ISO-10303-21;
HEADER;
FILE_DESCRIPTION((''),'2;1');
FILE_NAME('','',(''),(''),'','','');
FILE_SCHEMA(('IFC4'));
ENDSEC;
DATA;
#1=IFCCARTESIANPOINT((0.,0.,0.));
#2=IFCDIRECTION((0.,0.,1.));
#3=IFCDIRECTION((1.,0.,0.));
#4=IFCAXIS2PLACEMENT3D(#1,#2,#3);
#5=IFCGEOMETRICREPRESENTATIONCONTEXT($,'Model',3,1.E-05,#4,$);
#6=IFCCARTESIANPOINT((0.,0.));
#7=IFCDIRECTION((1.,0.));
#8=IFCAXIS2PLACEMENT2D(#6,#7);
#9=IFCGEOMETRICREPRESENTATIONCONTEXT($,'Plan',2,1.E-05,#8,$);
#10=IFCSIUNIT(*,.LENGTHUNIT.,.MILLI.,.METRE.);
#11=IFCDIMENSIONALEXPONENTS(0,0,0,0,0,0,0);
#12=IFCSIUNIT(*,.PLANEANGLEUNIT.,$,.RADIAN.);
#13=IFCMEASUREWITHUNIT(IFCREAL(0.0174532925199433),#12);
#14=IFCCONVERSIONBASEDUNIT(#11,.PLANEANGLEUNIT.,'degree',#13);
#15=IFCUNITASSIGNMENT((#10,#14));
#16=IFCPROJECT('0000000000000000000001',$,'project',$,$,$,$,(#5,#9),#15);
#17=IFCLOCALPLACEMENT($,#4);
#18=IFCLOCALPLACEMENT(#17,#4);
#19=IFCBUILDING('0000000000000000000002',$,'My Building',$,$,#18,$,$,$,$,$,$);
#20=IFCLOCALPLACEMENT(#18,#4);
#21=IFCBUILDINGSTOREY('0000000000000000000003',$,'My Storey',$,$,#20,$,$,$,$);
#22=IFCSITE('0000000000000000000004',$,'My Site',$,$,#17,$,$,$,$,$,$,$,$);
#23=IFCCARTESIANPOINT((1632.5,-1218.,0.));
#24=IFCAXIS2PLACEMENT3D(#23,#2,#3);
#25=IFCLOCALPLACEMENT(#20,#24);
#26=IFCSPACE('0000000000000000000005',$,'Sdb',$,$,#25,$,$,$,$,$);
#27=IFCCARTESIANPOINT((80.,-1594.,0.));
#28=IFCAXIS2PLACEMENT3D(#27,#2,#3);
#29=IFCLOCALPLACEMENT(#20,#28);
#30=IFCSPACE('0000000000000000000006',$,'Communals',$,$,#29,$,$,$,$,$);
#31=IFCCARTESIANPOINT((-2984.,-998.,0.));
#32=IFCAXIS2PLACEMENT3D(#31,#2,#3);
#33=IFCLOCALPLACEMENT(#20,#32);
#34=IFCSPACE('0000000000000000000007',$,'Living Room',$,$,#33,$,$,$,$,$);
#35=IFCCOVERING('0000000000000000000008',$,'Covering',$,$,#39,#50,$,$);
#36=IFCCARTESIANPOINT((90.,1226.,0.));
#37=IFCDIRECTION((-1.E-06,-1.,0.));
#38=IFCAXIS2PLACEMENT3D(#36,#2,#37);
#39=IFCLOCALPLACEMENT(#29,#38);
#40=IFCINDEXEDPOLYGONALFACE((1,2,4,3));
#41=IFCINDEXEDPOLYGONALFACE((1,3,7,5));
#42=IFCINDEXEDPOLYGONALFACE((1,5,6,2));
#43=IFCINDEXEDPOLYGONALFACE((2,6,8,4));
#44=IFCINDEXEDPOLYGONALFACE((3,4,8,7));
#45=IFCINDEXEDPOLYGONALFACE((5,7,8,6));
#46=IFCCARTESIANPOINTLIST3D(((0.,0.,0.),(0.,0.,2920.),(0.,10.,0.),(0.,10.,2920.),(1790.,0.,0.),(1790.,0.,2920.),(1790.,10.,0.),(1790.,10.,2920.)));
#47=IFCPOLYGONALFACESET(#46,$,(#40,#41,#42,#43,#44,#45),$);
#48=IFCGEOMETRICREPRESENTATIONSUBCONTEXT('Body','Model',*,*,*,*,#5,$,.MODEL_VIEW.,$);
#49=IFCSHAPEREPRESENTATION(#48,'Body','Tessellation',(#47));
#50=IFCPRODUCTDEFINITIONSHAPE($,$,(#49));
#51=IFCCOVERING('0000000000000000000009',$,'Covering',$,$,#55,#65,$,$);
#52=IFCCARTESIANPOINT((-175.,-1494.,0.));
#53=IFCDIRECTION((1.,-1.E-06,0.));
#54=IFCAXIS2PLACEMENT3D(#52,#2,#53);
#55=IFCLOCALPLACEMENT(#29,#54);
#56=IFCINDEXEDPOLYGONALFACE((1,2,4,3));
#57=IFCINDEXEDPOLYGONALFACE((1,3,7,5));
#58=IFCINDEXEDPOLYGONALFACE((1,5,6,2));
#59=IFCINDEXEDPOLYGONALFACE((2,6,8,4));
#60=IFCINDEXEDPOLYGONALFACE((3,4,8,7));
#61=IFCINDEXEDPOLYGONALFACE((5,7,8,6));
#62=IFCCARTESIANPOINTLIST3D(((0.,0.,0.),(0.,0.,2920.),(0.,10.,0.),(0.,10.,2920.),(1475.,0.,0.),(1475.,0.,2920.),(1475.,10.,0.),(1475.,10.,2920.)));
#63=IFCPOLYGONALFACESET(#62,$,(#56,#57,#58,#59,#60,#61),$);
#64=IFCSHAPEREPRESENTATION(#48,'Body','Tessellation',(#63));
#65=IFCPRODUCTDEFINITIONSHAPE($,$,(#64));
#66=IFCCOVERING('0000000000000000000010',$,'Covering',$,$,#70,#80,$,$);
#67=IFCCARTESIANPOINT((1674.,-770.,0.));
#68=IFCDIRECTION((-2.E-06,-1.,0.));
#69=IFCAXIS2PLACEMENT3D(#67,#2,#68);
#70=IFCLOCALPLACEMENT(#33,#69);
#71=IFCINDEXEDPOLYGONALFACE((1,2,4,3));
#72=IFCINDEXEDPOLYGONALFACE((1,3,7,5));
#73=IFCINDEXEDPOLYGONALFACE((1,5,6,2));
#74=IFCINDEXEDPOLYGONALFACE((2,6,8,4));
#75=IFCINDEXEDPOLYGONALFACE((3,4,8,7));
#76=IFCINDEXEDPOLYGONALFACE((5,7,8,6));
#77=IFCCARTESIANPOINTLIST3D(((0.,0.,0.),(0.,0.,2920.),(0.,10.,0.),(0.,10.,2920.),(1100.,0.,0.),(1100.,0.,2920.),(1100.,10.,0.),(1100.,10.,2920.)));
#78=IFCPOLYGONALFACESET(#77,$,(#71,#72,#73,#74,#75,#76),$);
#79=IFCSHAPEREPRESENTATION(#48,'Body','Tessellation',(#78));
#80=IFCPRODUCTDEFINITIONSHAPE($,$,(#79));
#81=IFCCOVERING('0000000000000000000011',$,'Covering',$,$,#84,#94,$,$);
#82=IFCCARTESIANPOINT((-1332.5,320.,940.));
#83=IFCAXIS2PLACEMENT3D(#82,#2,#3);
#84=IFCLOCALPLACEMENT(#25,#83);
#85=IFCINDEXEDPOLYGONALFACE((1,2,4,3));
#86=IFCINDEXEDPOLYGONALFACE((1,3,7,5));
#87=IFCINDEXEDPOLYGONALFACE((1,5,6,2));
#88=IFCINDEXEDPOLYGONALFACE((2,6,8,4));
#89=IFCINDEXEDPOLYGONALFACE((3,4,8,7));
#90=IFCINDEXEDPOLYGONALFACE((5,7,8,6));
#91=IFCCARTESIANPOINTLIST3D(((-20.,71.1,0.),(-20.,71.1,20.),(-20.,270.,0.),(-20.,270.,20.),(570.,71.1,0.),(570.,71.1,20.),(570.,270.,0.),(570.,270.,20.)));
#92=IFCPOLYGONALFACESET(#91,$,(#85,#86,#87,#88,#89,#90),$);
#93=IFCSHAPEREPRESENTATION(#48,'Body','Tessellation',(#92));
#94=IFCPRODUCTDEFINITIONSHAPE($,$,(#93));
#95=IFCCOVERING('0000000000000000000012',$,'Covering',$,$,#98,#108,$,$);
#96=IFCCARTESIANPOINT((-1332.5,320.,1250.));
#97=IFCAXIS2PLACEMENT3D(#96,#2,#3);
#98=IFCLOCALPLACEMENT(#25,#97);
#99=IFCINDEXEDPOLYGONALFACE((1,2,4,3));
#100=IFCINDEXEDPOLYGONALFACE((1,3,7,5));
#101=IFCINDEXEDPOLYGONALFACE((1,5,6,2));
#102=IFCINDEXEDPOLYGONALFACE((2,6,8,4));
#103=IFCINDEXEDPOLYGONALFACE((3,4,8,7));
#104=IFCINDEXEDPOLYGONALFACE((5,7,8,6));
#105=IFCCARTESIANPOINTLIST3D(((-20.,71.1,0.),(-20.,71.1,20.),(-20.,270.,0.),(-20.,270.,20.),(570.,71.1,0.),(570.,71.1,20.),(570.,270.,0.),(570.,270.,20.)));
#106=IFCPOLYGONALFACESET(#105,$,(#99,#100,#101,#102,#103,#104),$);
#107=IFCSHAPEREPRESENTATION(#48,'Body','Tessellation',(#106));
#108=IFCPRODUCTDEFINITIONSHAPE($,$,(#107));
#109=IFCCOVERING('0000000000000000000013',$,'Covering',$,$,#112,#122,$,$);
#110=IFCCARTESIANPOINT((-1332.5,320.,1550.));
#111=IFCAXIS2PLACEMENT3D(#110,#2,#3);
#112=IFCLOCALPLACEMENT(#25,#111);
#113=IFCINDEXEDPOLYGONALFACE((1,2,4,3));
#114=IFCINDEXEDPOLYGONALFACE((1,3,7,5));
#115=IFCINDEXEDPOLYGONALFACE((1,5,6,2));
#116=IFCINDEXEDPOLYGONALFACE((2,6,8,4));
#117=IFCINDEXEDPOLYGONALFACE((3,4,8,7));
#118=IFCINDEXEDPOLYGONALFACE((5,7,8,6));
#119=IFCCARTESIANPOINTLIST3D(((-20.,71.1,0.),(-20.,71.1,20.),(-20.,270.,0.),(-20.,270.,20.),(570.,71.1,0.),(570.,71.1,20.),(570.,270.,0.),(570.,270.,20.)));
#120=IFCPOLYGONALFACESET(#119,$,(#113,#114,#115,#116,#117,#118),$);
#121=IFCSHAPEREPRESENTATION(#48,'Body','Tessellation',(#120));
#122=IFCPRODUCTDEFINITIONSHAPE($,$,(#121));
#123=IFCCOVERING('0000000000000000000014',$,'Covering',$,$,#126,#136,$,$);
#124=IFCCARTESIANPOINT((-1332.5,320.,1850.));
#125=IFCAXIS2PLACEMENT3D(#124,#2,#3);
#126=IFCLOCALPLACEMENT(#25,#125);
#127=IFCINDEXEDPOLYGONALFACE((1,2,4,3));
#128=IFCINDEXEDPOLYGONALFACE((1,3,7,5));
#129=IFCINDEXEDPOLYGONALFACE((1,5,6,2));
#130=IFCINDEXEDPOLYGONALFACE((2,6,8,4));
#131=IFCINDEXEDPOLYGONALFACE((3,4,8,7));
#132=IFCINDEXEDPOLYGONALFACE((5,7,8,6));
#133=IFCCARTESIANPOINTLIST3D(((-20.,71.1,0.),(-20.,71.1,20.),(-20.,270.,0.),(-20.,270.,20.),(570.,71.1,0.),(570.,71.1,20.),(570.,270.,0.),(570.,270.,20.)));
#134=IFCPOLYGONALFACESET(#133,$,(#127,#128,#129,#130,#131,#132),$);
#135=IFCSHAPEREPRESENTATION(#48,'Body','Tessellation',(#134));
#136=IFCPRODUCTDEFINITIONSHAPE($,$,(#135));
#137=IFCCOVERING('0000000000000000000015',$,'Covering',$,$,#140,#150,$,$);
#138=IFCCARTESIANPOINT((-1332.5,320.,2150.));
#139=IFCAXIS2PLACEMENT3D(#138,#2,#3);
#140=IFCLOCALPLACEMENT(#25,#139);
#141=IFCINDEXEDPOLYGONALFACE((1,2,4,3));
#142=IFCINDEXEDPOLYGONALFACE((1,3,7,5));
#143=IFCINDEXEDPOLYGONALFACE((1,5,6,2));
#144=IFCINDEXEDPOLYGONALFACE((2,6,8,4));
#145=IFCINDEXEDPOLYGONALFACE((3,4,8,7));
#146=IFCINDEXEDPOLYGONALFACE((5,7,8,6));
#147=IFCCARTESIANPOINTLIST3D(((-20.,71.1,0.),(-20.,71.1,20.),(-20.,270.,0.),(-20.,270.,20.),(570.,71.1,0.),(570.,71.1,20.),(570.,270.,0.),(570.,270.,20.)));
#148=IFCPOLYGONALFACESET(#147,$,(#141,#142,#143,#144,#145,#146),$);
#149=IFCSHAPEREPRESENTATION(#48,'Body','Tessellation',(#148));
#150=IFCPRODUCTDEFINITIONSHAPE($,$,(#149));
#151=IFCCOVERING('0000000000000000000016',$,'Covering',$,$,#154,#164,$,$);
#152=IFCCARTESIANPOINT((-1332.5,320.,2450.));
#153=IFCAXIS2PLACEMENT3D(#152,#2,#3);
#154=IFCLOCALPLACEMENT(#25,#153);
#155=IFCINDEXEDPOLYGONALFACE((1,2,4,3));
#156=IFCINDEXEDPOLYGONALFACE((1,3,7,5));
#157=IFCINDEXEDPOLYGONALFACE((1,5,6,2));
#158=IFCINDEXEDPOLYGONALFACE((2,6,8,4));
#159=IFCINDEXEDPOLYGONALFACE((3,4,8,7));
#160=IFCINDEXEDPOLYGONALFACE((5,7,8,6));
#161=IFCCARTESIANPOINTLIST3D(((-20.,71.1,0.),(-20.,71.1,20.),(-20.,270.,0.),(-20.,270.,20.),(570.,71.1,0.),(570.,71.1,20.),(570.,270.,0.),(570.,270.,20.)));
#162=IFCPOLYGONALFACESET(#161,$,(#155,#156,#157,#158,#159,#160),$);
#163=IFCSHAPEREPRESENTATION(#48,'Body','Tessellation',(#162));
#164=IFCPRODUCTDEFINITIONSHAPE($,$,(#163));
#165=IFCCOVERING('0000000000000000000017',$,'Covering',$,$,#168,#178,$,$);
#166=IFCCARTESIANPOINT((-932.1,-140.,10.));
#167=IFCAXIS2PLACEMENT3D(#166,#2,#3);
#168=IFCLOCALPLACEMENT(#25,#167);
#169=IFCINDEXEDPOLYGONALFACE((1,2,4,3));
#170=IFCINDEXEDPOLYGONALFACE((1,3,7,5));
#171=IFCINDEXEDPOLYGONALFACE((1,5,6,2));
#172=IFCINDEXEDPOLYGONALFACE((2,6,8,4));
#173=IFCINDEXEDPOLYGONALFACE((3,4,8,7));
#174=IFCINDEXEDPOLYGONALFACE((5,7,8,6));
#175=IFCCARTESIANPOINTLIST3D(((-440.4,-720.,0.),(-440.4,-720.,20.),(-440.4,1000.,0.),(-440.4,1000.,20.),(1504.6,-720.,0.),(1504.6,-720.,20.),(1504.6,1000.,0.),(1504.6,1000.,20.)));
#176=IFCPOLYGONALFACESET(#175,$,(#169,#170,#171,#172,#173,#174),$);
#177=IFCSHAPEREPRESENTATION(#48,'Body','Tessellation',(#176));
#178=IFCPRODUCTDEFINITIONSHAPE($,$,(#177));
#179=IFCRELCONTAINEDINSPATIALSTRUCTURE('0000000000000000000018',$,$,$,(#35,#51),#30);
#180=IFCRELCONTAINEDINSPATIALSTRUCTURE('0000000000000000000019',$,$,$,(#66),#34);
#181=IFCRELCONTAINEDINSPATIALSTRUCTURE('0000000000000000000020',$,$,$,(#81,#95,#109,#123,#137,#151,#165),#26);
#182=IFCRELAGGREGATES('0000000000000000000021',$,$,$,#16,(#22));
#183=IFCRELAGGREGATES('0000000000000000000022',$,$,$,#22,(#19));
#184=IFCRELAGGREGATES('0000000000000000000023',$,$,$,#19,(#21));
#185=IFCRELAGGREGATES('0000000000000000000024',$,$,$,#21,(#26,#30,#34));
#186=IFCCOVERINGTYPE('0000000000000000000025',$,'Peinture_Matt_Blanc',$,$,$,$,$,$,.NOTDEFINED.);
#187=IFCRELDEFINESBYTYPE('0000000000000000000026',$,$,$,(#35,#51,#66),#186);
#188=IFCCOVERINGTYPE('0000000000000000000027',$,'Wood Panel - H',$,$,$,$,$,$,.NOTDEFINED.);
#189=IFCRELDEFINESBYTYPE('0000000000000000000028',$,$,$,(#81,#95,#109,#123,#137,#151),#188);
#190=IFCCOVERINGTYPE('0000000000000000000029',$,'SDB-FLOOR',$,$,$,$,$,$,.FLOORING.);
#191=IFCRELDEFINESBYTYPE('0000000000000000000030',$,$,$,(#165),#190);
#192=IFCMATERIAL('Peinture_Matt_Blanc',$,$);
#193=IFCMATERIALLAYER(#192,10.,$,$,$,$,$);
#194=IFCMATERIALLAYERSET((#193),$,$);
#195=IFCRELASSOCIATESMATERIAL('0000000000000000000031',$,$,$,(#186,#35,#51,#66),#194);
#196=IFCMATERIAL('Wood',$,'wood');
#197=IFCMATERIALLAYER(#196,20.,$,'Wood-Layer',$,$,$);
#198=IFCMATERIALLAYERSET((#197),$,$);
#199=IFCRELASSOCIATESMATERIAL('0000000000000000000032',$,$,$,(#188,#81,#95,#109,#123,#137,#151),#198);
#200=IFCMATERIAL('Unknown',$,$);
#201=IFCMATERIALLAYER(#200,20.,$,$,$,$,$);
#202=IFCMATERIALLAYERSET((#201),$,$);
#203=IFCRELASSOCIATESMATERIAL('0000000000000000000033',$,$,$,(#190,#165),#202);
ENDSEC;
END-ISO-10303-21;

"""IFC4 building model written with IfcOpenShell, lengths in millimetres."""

from ifc_helpers import new_model, entity, si_unit, converted_unit, frame, origin_with_axes, origin_2d_with_axis, place, context, subcontext, project, spatial, line, indexed_curve, outline, extrude, clip, halfspace, material, layer, layer_set, layer_usage, type_object, element, save


model = new_model("IFC4")

# Units and contexts
model_context = context("Model", 3, precision=1e-05, world=origin_with_axes())
plan_context = context("Plan", 2, precision=1e-05, world=origin_2d_with_axis())
body_context = subcontext(model_context, "Body", "Model", "MODEL_VIEW")
ifc_project = project(units=[si_unit("LENGTHUNIT", "METRE", prefix="MILLI"), converted_unit("PLANEANGLEUNIT", "degree", entity("IfcReal", 0.0174532925199433), si_unit("PLANEANGLEUNIT", "RADIAN"), dimensions=[0, 0, 0, 0, 0, 0, 0])], contexts=[model_context, plan_context])

# Site, building, storey, space
site_placement = place(None, origin_with_axes())
site = spatial("IfcSite", under=ifc_project, at=site_placement, Name="My Site")
building_placement = place(site_placement, origin_with_axes())
building = spatial("IfcBuilding", under=site, at=building_placement, Name="My Building")
storey_placement = place(building_placement, origin_with_axes())
storey = spatial("IfcBuildingStorey", under=building, at=storey_placement, Name="My Storey")
space_1_placement = place(storey_placement, frame((1632.5, -1218.0, 0.0), z_axis=(0.0, 0.0, 1.0), x_axis=(1.0, 0.0, 0.0)))
space_1 = spatial("IfcSpace", under=storey, at=space_1_placement, Name="Sdb")

# Shared definitions
space_2_placement = place(storey_placement, frame((80.0, -1594.0, 0.0), z_axis=(0.0, 0.0, 1.0), x_axis=(1.0, 0.0, 0.0)))
space_2 = spatial("IfcSpace", under=storey, at=space_2_placement, Name="Communals")

# Coverings
ifc_material_1 = material(Name="Peinture_Matt_Blanc")
ifc_layer_1 = layer(ifc_material_1, 10.0)
ifc_layer_set_1 = layer_set([ifc_layer_1])
ifc_layer_usage_1 = layer_usage(ifc_layer_set_1, "AXIS2", "POSITIVE", 0.0)
covering_type_1 = type_object("IfcCoveringType", Name="Peinture_Matt_Blanc", PredefinedType="NOTDEFINED", material=ifc_layer_set_1)
covering_1_placement = place(space_2_placement, frame((90.0, 1226.0, 0.0), z_axis=(0.0, 0.0, 1.0), x_axis=(-0.000001, -1.0, 0.0)))
element("IfcCovering", 1, at=covering_1_placement, inside=space_2, type_object=covering_type_1, material=ifc_layer_usage_1, Name="Covering", context=body_context, shape_type="Clipping", body=[
    clip(clip(extrude(outline(indexed_curve([(0.0, 0.0), (0.0, 10.0), (1790.0, 10.0), (1790.0, 0.0), (0.0, 0.0)], self_intersect=False)), origin_with_axes(), (0.0, 0.0, 1.0), 2920.0), halfspace(frame((0.0, 0.0, 2920.0), z_axis=(0.0, 0.0, 1.0), x_axis=(-1.0, 0.0, 0.0)), False)), halfspace(frame((0.0, 0.0, 2920.0), z_axis=(0.0, 0.0, 1.0), x_axis=(-1.0, 0.0, 0.0)), False)),
])
ifc_layer_usage_2 = layer_usage(ifc_layer_set_1, "AXIS2", "POSITIVE", 0.0)
covering_2_placement = place(space_2_placement, frame((-175.0, -1494.0, 0.0), z_axis=(0.0, 0.0, 1.0), x_axis=(1.0, -0.000001, 0.0)))
element("IfcCovering", 2, at=covering_2_placement, inside=space_2, type_object=covering_type_1, material=ifc_layer_usage_2, Name="Covering", context=body_context, shape_type="Clipping", body=[
    clip(clip(extrude(outline(indexed_curve([(0.0, 0.0), (0.0, 10.0), (1475.0, 10.0), (1475.0, 0.0), (0.0, 0.0)], self_intersect=False)), origin_with_axes(), (0.0, 0.0, 1.0), 2920.0), halfspace(frame((0.0, 0.0, 2920.0), z_axis=(0.0, 0.0, 1.0), x_axis=(-1.0, 0.0, 0.0)), False)), halfspace(frame((0.0, 0.0, 2920.0), z_axis=(0.0, 0.0, 1.0), x_axis=(-1.0, 0.0, 0.0)), False)),
])

# Shared definitions
space_3_placement = place(storey_placement, frame((-2984.0, -998.0, 0.0), z_axis=(0.0, 0.0, 1.0), x_axis=(1.0, 0.0, 0.0)))
space_3 = spatial("IfcSpace", under=storey, at=space_3_placement, Name="Living Room")

# Coverings
ifc_layer_usage_3 = layer_usage(ifc_layer_set_1, "AXIS2", "POSITIVE", 0.0)
covering_3_placement = place(space_3_placement, frame((1674.0, -770.0, 0.0), z_axis=(0.0, 0.0, 1.0), x_axis=(-0.000002, -1.0, 0.0)))
element("IfcCovering", 3, at=covering_3_placement, inside=space_3, type_object=covering_type_1, material=ifc_layer_usage_3, Name="Covering", context=body_context, shape_type="Clipping", body=[
    clip(clip(extrude(outline(indexed_curve([(0.0, 0.0), (0.0, 10.0), (1100.0, 10.0), (1100.0, 0.0), (0.0, 0.0)], self_intersect=False)), origin_with_axes(), (0.0, 0.0, 1.0), 2920.0), halfspace(frame((0.0, 0.0, 2920.0), z_axis=(0.0, 0.0, 1.0), x_axis=(-1.0, 0.0, 0.0)), False)), halfspace(frame((0.0, 0.0, 2920.0), z_axis=(0.0, 0.0, 1.0), x_axis=(-1.0, 0.0, 0.0)), False)),
])
ifc_material_2 = material(Name="Wood", Category="wood")
ifc_layer_2 = layer(ifc_material_2, 20.0, Name="Wood-Layer")
ifc_layer_set_2 = layer_set([ifc_layer_2])
ifc_layer_usage_4 = layer_usage(ifc_layer_set_2, "AXIS3", "POSITIVE", 0.0)
covering_type_2 = type_object("IfcCoveringType", Name="Wood Panel - H", PredefinedType="NOTDEFINED", material=ifc_layer_set_2)
covering_4_placement = place(space_1_placement, frame((-1332.5, 320.0, 940.0), z_axis=(0.0, 0.0, 1.0), x_axis=(1.0, 0.0, 0.0)))
element("IfcCovering", 4, at=covering_4_placement, inside=space_1, type_object=covering_type_2, material=ifc_layer_usage_4, Name="Covering", context=body_context, shape_type="SweptSolid", body=[
    extrude(outline(indexed_curve([(-20.0, 71.1), (570.0, 71.1), (570.0, 270.0), (-20.0, 270.0)], segments=[line(4, 1), line(1, 2), line(2, 3), line(3, 4)], self_intersect=False)), None, (0.0, 0.0, 1.0), 20.0),
])
ifc_layer_usage_5 = layer_usage(ifc_layer_set_2, "AXIS3", "POSITIVE", 0.0)
covering_5_placement = place(space_1_placement, frame((-1332.5, 320.0, 1250.0), z_axis=(0.0, 0.0, 1.0), x_axis=(1.0, 0.0, 0.0)))
element("IfcCovering", 5, at=covering_5_placement, inside=space_1, type_object=covering_type_2, material=ifc_layer_usage_5, Name="Covering", context=body_context, shape_type="SweptSolid", body=[
    extrude(outline(indexed_curve([(-20.0, 71.1), (570.0, 71.1), (570.0, 270.0), (-20.0, 270.0)], segments=[line(4, 1), line(1, 2), line(2, 3), line(3, 4)], self_intersect=False)), None, (0.0, 0.0, 1.0), 20.0),
])
ifc_layer_usage_6 = layer_usage(ifc_layer_set_2, "AXIS3", "POSITIVE", 0.0)
covering_6_placement = place(space_1_placement, frame((-1332.5, 320.0, 1550.0), z_axis=(0.0, 0.0, 1.0), x_axis=(1.0, 0.0, 0.0)))
element("IfcCovering", 6, at=covering_6_placement, inside=space_1, type_object=covering_type_2, material=ifc_layer_usage_6, Name="Covering", context=body_context, shape_type="SweptSolid", body=[
    extrude(outline(indexed_curve([(-20.0, 71.1), (570.0, 71.1), (570.0, 270.0), (-20.0, 270.0)], segments=[line(4, 1), line(1, 2), line(2, 3), line(3, 4)], self_intersect=False)), None, (0.0, 0.0, 1.0), 20.0),
])
ifc_layer_usage_7 = layer_usage(ifc_layer_set_2, "AXIS3", "POSITIVE", 0.0)
covering_7_placement = place(space_1_placement, frame((-1332.5, 320.0, 1850.0), z_axis=(0.0, 0.0, 1.0), x_axis=(1.0, 0.0, 0.0)))
element("IfcCovering", 7, at=covering_7_placement, inside=space_1, type_object=covering_type_2, material=ifc_layer_usage_7, Name="Covering", context=body_context, shape_type="SweptSolid", body=[
    extrude(outline(indexed_curve([(-20.0, 71.1), (570.0, 71.1), (570.0, 270.0), (-20.0, 270.0)], segments=[line(4, 1), line(1, 2), line(2, 3), line(3, 4)], self_intersect=False)), None, (0.0, 0.0, 1.0), 20.0),
])
ifc_layer_usage_8 = layer_usage(ifc_layer_set_2, "AXIS3", "POSITIVE", 0.0)
covering_8_placement = place(space_1_placement, frame((-1332.5, 320.0, 2150.0), z_axis=(0.0, 0.0, 1.0), x_axis=(1.0, 0.0, 0.0)))
element("IfcCovering", 8, at=covering_8_placement, inside=space_1, type_object=covering_type_2, material=ifc_layer_usage_8, Name="Covering", context=body_context, shape_type="SweptSolid", body=[
    extrude(outline(indexed_curve([(-20.0, 71.1), (570.0, 71.1), (570.0, 270.0), (-20.0, 270.0)], segments=[line(4, 1), line(1, 2), line(2, 3), line(3, 4)], self_intersect=False)), None, (0.0, 0.0, 1.0), 20.0),
])
ifc_layer_usage_9 = layer_usage(ifc_layer_set_2, "AXIS3", "POSITIVE", 0.0)
covering_9_placement = place(space_1_placement, frame((-1332.5, 320.0, 2450.0), z_axis=(0.0, 0.0, 1.0), x_axis=(1.0, 0.0, 0.0)))
element("IfcCovering", 9, at=covering_9_placement, inside=space_1, type_object=covering_type_2, material=ifc_layer_usage_9, Name="Covering", context=body_context, shape_type="SweptSolid", body=[
    extrude(outline(indexed_curve([(-20.0, 71.1), (570.0, 71.1), (570.0, 270.0), (-20.0, 270.0)], segments=[line(4, 1), line(1, 2), line(2, 3), line(3, 4)], self_intersect=False)), None, (0.0, 0.0, 1.0), 20.0),
])
ifc_material_3 = material(Name="Unknown")
ifc_layer_3 = layer(ifc_material_3, 20.0)
ifc_layer_set_3 = layer_set([ifc_layer_3])
ifc_layer_usage_10 = layer_usage(ifc_layer_set_3, "AXIS3", "POSITIVE", 0.0)
covering_type_3 = type_object("IfcCoveringType", Name="SDB-FLOOR", PredefinedType="FLOORING", material=ifc_layer_set_3)
covering_10_placement = place(space_1_placement, frame((-932.1, -140.0, 10.0), z_axis=(0.0, 0.0, 1.0), x_axis=(1.0, 0.0, 0.0)))
element("IfcCovering", 10, at=covering_10_placement, inside=space_1, type_object=covering_type_3, material=ifc_layer_usage_10, Name="Covering", context=body_context, shape_type="SweptSolid", body=[
    extrude(outline(indexed_curve([(-440.4, 1000.0), (-440.4, -720.0), (1504.6, -720.0), (1504.6, 1000.0)], segments=[line(4, 1), line(1, 2), line(2, 3), line(3, 4)], self_intersect=False)), None, (0.0, 0.0, 1.0), 20.0),
])

save(model, "model.ifc")
